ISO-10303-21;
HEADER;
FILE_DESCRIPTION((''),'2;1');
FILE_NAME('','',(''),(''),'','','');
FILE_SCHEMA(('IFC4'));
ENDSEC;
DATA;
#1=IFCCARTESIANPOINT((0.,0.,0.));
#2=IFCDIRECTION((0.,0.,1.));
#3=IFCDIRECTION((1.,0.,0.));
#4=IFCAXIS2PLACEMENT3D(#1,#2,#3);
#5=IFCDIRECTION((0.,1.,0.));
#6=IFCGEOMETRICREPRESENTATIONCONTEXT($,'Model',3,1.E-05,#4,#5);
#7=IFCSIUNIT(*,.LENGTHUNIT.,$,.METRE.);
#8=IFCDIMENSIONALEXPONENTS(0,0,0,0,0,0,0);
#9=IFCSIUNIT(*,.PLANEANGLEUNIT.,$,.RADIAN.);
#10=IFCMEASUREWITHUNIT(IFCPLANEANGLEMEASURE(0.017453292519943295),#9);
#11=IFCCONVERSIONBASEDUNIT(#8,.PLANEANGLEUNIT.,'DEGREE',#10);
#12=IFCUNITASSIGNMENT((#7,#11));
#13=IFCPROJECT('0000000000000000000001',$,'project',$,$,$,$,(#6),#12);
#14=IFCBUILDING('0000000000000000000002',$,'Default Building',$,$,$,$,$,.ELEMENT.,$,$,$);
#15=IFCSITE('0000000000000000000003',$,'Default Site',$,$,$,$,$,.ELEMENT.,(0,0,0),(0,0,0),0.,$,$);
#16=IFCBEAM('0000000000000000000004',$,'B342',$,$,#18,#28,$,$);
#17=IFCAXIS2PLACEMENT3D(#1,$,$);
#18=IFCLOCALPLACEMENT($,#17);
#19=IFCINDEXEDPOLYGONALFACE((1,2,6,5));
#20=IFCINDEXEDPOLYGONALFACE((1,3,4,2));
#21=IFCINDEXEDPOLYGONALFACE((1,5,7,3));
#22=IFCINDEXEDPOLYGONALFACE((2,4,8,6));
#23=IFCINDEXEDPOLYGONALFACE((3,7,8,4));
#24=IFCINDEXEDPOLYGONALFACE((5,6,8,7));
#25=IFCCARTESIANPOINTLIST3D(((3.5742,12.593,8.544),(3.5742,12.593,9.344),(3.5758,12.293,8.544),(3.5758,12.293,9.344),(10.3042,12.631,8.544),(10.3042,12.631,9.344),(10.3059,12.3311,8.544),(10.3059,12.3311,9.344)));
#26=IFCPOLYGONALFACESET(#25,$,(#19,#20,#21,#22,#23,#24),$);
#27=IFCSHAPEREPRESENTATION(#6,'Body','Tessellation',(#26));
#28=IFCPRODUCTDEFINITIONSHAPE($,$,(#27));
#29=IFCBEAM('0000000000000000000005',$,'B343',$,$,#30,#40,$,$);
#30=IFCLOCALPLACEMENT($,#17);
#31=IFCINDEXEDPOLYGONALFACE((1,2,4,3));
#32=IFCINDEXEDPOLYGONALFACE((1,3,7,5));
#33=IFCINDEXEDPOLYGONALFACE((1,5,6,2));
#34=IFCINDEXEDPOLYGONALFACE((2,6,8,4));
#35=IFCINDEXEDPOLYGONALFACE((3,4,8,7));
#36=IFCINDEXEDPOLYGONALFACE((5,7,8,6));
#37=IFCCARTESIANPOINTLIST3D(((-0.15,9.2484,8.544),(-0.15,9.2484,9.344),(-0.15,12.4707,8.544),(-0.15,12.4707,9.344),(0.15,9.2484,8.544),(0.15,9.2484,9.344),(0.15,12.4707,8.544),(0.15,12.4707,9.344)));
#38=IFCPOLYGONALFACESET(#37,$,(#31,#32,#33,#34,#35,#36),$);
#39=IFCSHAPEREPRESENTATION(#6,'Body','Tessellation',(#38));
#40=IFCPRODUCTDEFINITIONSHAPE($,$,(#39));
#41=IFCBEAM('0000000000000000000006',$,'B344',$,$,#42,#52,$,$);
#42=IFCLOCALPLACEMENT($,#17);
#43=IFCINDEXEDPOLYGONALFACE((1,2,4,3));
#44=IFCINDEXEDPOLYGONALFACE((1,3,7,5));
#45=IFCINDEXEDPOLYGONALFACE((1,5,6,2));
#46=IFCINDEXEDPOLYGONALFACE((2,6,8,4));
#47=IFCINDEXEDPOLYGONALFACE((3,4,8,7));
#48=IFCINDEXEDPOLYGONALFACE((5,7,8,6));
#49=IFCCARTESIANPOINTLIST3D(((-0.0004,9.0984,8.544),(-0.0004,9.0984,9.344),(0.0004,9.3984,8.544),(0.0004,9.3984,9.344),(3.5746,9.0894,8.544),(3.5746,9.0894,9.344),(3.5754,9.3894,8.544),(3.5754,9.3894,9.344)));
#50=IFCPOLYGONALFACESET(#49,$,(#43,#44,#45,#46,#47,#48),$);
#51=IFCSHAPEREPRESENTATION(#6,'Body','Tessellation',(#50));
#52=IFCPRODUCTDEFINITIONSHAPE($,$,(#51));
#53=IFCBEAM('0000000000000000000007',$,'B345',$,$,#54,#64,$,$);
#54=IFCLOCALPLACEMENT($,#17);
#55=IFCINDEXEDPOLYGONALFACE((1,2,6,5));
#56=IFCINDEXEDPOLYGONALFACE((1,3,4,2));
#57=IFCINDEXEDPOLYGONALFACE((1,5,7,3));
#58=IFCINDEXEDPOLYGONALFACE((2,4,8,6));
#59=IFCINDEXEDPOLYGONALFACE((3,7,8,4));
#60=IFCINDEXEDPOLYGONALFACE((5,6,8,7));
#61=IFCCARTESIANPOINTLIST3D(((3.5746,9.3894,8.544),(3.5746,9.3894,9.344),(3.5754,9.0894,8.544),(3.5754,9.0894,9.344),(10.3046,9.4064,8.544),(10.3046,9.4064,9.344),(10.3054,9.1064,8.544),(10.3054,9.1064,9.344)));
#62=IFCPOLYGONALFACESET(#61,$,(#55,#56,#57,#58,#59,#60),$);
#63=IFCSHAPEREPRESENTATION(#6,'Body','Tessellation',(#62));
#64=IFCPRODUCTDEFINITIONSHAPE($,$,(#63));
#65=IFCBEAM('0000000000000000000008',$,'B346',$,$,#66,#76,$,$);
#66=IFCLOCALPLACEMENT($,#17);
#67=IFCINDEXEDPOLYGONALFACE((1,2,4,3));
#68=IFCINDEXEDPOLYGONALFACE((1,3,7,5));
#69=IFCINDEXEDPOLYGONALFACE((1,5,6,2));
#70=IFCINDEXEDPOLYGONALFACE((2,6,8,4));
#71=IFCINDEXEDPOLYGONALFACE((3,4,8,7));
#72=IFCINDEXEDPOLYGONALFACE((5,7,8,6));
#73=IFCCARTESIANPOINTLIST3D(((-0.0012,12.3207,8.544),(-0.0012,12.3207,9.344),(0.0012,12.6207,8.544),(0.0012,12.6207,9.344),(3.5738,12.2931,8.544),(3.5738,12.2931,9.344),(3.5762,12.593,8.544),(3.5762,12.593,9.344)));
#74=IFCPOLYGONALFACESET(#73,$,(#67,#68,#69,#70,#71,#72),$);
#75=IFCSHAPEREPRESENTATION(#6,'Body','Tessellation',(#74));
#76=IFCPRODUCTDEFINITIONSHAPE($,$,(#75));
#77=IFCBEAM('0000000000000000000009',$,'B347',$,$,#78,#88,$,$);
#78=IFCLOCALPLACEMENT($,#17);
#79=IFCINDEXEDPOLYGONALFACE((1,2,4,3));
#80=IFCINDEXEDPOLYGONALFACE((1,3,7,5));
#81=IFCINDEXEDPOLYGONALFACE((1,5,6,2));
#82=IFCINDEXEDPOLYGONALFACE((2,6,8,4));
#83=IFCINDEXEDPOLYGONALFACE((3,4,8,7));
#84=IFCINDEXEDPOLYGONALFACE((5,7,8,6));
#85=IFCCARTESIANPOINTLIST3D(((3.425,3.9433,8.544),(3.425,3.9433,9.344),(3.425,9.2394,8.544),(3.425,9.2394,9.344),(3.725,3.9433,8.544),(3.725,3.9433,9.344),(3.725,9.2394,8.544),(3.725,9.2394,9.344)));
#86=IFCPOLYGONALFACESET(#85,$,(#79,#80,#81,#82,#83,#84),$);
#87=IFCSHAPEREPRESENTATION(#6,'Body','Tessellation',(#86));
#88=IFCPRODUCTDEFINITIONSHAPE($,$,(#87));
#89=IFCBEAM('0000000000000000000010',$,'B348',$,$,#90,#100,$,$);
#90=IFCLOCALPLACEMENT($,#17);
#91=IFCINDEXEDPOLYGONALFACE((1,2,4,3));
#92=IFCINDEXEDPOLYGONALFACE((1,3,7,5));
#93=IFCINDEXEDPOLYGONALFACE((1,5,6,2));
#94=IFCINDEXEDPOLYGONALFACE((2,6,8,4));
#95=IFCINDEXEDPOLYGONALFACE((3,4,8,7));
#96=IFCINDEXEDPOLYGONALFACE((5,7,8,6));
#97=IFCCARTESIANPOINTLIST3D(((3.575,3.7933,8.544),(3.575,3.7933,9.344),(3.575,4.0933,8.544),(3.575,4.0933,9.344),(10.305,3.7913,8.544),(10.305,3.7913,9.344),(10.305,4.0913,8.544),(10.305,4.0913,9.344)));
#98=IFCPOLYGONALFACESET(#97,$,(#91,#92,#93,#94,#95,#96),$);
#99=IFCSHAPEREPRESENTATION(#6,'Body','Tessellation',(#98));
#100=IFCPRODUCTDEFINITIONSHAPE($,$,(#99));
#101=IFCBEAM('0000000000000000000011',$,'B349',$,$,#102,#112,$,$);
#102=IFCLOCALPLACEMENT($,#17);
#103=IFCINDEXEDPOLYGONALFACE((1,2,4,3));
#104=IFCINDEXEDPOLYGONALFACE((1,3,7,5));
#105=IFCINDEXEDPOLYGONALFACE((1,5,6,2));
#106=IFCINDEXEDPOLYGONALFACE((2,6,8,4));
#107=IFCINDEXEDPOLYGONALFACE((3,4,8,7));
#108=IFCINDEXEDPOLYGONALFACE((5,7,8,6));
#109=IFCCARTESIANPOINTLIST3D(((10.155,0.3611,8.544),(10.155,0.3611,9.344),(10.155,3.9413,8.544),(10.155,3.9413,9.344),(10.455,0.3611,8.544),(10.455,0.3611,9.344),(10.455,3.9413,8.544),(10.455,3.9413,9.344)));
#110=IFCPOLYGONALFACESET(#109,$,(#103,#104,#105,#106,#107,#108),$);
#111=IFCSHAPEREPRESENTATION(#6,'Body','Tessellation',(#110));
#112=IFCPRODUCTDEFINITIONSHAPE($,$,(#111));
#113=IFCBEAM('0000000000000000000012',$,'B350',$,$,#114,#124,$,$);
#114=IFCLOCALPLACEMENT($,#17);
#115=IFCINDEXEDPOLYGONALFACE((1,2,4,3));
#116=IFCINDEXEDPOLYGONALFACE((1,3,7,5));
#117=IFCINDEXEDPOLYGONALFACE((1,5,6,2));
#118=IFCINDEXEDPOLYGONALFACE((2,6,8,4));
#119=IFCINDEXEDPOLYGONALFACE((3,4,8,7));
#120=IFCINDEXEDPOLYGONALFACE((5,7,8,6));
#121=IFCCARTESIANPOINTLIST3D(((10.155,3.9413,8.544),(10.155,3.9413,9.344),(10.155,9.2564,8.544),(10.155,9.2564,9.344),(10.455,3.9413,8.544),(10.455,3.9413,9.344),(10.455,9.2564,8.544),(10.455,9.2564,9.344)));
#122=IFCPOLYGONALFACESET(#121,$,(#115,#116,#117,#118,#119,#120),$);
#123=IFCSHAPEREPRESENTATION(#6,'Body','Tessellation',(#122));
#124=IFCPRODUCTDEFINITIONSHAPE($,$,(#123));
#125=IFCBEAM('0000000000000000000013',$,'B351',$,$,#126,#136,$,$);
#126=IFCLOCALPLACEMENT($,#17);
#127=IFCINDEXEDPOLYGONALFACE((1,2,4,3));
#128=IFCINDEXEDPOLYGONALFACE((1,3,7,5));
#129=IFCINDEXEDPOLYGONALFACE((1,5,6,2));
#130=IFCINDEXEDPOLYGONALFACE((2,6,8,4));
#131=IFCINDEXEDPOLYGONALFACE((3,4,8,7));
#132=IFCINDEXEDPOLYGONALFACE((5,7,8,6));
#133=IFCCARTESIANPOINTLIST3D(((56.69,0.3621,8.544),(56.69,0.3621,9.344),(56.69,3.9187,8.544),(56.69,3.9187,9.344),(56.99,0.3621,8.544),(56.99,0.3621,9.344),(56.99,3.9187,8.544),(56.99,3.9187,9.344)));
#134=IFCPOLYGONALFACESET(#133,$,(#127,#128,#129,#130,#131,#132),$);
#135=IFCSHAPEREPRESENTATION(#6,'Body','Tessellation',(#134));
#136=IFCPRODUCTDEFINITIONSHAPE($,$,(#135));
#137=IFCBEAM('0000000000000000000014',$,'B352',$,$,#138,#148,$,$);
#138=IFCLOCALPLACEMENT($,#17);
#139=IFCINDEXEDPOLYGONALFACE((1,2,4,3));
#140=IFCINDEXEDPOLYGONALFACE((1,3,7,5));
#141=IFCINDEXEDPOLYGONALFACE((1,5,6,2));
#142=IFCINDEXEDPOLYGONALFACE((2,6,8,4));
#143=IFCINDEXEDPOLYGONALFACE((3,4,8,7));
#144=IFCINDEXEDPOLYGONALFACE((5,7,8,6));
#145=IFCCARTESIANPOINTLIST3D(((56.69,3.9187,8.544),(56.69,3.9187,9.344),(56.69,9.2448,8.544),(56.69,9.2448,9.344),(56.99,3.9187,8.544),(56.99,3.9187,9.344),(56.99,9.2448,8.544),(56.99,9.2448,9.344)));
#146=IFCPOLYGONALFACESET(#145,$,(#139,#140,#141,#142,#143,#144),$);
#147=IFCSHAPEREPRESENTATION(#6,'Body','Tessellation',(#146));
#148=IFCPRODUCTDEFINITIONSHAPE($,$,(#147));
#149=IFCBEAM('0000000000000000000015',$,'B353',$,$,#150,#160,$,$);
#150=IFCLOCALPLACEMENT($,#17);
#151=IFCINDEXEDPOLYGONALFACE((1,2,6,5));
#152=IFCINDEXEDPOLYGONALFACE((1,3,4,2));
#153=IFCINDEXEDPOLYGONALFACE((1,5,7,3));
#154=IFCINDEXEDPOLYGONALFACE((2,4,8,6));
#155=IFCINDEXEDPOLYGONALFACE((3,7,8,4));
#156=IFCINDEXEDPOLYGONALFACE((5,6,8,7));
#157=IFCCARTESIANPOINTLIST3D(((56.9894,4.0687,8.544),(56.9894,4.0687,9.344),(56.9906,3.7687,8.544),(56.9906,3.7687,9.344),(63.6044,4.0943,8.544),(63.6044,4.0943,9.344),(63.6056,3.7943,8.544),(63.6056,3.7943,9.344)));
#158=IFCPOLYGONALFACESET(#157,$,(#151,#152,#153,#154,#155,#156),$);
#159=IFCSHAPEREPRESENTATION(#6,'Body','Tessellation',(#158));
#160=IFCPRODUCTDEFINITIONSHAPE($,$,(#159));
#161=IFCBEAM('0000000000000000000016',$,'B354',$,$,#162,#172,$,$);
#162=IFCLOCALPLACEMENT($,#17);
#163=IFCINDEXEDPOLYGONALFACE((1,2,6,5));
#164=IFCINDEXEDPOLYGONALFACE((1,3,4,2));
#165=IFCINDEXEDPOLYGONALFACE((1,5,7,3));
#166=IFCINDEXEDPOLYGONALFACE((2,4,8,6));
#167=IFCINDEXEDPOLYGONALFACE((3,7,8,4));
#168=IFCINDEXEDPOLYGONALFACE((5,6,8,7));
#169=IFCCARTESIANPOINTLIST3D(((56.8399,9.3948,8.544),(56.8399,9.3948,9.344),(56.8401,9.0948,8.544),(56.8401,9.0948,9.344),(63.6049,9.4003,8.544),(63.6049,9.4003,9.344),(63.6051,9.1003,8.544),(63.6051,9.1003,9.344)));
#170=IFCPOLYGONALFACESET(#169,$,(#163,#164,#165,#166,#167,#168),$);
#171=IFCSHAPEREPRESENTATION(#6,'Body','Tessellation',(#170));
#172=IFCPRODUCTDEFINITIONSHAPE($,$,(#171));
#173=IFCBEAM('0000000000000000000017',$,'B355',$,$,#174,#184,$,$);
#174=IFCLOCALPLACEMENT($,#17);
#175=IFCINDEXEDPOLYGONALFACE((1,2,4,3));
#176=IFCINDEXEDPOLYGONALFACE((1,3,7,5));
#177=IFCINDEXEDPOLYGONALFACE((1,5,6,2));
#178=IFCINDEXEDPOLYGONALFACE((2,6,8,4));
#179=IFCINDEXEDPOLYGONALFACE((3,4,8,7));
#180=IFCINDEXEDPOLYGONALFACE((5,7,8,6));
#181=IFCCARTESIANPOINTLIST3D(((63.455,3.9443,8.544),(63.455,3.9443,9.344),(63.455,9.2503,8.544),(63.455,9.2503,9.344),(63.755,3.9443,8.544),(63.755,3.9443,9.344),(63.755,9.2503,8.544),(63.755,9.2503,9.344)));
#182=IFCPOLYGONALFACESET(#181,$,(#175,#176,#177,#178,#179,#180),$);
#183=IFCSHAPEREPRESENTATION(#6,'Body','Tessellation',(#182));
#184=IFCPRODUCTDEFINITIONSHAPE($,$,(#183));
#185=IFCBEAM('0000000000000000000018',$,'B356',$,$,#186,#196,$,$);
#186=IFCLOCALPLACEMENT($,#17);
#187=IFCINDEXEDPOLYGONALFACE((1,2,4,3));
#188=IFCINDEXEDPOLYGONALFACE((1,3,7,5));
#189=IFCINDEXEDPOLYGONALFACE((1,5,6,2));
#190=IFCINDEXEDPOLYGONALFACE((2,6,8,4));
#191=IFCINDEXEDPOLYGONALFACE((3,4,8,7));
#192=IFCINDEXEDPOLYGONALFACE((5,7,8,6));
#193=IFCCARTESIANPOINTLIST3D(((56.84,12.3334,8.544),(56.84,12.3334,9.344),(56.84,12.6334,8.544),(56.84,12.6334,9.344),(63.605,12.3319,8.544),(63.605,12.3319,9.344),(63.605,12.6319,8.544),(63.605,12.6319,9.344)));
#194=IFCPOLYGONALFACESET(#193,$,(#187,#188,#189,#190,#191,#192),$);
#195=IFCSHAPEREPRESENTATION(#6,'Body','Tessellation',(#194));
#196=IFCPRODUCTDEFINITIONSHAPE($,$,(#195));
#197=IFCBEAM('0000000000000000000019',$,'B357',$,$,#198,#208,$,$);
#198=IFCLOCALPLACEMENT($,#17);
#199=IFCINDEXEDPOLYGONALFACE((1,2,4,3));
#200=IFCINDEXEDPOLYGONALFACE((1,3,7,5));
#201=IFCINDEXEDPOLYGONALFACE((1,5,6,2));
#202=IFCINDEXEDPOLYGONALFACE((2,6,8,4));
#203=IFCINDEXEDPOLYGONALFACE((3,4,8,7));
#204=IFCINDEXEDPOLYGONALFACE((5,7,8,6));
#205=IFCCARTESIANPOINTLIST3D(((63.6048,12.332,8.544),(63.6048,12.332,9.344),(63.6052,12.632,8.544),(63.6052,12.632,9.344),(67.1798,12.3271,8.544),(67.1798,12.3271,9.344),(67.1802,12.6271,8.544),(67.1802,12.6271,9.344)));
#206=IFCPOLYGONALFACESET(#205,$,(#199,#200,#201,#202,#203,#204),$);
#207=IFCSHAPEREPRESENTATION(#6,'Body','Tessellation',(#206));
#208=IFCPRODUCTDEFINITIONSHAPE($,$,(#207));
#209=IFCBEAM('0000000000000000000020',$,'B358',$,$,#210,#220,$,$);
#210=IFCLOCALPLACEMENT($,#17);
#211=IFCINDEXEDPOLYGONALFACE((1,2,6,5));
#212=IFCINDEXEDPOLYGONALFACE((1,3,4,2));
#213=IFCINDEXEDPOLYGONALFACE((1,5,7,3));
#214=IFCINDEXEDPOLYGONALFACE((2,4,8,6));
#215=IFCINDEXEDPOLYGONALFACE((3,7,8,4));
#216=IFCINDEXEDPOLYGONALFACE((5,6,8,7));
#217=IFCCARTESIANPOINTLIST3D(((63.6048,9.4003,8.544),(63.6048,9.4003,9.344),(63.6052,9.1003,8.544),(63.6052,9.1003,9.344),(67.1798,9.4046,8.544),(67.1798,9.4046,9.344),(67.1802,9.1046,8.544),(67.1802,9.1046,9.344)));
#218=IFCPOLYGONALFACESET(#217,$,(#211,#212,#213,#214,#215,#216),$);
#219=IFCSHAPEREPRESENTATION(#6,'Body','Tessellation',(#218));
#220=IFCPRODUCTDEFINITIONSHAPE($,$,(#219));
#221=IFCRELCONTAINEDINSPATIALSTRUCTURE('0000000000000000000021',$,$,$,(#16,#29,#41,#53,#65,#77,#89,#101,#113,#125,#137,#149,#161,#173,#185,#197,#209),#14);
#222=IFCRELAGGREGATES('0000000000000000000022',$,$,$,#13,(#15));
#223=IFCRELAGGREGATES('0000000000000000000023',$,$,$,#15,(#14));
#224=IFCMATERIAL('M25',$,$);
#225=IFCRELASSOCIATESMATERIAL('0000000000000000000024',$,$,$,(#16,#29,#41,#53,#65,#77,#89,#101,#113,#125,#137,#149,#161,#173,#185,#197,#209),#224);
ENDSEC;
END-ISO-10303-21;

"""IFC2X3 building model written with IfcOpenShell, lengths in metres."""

from ifc_helpers import new_model, entity, si_unit, converted_unit, direction, frame, frame_2d, origin_with_axes, place, context, project, spatial, rectangle, extrude, material, element, save


model = new_model("IFC2X3")

# Units and contexts
model_context = context("Model", 3, precision=1e-05, world=origin_with_axes(), true_north=direction((0.0, 1.0, 0.0)))
ifc_project = project(units=[si_unit("LENGTHUNIT", "METRE"), converted_unit("PLANEANGLEUNIT", "DEGREE", entity("IfcPlaneAngleMeasure", 0.017453292519943295), si_unit("PLANEANGLEUNIT", "RADIAN"), dimensions=[0, 0, 0, 0, 0, 0, 0])], contexts=[model_context])

# Site, building
site = spatial("IfcSite", under=ifc_project, Name="Default Site", CompositionType="ELEMENT", RefLatitude=(0, 0, 0), RefLongitude=(0, 0, 0), RefElevation=0.0)
building = spatial("IfcBuilding", under=site, Name="Default Building", CompositionType="ELEMENT")

# Beams
ifc_material = material(Name="M25")
placement = place(None, origin_with_axes())
element("IfcBeam", 1, at=placement, inside=building, material=ifc_material, Name="B342", context=model_context, shape_type="SweptSolid", body=[
    extrude(rectangle(XDim=0.3, YDim=0.8, at=frame_2d((0.0, 0.0), x_axis=(0.0, 1.0, 0.0))), frame((3.575, 12.443, 8.944), z_axis=(0.999984, 0.005654, 0.0), x_axis=(0.0, 0.0, -1.0)), (0.0, 0.0, 1.0), 6.7301),
])
element("IfcBeam", 2, at=placement, inside=building, material=ifc_material, Name="B343", context=model_context, shape_type="SweptSolid", body=[
    extrude(rectangle(XDim=0.3, YDim=0.8, at=frame_2d((0.0, 0.0), x_axis=(0.0, 1.0, 0.0))), frame((0.0, 9.2484, 8.944), z_axis=(0.0, 1.0, 0.0), x_axis=(0.0, 0.0, -1.0)), (0.0, 0.0, 1.0), 3.2223),
])
element("IfcBeam", 3, at=placement, inside=building, material=ifc_material, Name="B344", context=model_context, shape_type="SweptSolid", body=[
    extrude(rectangle(XDim=0.3, YDim=0.8, at=frame_2d((0.0, 0.0), x_axis=(0.0, 1.0, 0.0))), frame((0.0, 9.2484, 8.944), z_axis=(0.999997, -0.002499, 0.0), x_axis=(0.0, 0.0, -1.0)), (0.0, 0.0, 1.0), 3.575),
])
element("IfcBeam", 4, at=placement, inside=building, material=ifc_material, Name="B345", context=model_context, shape_type="SweptSolid", body=[
    extrude(rectangle(XDim=0.3, YDim=0.8, at=frame_2d((0.0, 0.0), x_axis=(0.0, 1.0, 0.0))), frame((3.575, 9.2394, 8.944), z_axis=(0.999997, 0.002522, 0.0), x_axis=(0.0, 0.0, -1.0)), (0.0, 0.0, 1.0), 6.73),
])
element("IfcBeam", 5, at=placement, inside=building, material=ifc_material, Name="B346", context=model_context, shape_type="SweptSolid", body=[
    extrude(rectangle(XDim=0.3, YDim=0.8, at=frame_2d((0.0, 0.0), x_axis=(0.0, 1.0, 0.0))), frame((0.0, 12.4707, 8.944), z_axis=(0.99997, -0.007734, 0.0), x_axis=(0.0, 0.0, -1.0)), (0.0, 0.0, 1.0), 3.5751),
])
element("IfcBeam", 6, at=placement, inside=building, material=ifc_material, Name="B347", context=model_context, shape_type="SweptSolid", body=[
    extrude(rectangle(XDim=0.3, YDim=0.8, at=frame_2d((0.0, 0.0), x_axis=(0.0, 1.0, 0.0))), frame((3.575, 3.9433, 8.944), z_axis=(0.0, 1.0, 0.0), x_axis=(0.0, 0.0, -1.0)), (0.0, 0.0, 1.0), 5.2961),
])
element("IfcBeam", 7, at=placement, inside=building, material=ifc_material, Name="B348", context=model_context, shape_type="SweptSolid", body=[
    extrude(rectangle(XDim=0.3, YDim=0.8, at=frame_2d((0.0, 0.0), x_axis=(0.0, 1.0, 0.0))), frame((3.575, 3.9433, 8.944), z_axis=(1.0, -0.000302, 0.0), x_axis=(0.0, 0.0, -1.0)), (0.0, 0.0, 1.0), 6.73),
])
element("IfcBeam", 8, at=placement, inside=building, material=ifc_material, Name="B349", context=model_context, shape_type="SweptSolid", body=[
    extrude(rectangle(XDim=0.3, YDim=0.8, at=frame_2d((0.0, 0.0), x_axis=(0.0, 1.0, 0.0))), frame((10.305, 3.9413, 8.944), z_axis=(0.0, -1.0, 0.0), x_axis=(0.0, 0.0, -1.0)), (0.0, 0.0, 1.0), 3.5802),
])
element("IfcBeam", 9, at=placement, inside=building, material=ifc_material, Name="B350", context=model_context, shape_type="SweptSolid", body=[
    extrude(rectangle(XDim=0.3, YDim=0.8, at=frame_2d((0.0, 0.0), x_axis=(0.0, 1.0, 0.0))), frame((10.305, 3.9413, 8.944), z_axis=(0.0, 1.0, 0.0), x_axis=(0.0, 0.0, -1.0)), (0.0, 0.0, 1.0), 5.3151),
])
element("IfcBeam", 10, at=placement, inside=building, material=ifc_material, Name="B351", context=model_context, shape_type="SweptSolid", body=[
    extrude(rectangle(XDim=0.3, YDim=0.8, at=frame_2d((0.0, 0.0), x_axis=(0.0, 1.0, 0.0))), frame((56.84, 0.3621, 8.944), z_axis=(0.0, 1.0, 0.0), x_axis=(0.0, 0.0, -1.0)), (0.0, 0.0, 1.0), 3.5566),
])
element("IfcBeam", 11, at=placement, inside=building, material=ifc_material, Name="B352", context=model_context, shape_type="SweptSolid", body=[
    extrude(rectangle(XDim=0.3, YDim=0.8, at=frame_2d((0.0, 0.0), x_axis=(0.0, 1.0, 0.0))), frame((56.84, 3.9187, 8.944), z_axis=(0.0, 1.0, 0.0), x_axis=(0.0, 0.0, -1.0)), (0.0, 0.0, 1.0), 5.3261),
])
element("IfcBeam", 12, at=placement, inside=building, material=ifc_material, Name="B353", context=model_context, shape_type="SweptSolid", body=[
    extrude(rectangle(XDim=0.3, YDim=0.8, at=frame_2d((0.0, 0.0), x_axis=(0.0, 1.0, 0.0))), frame((56.99, 3.9187, 8.944), z_axis=(0.999993, 0.003873, 0.0), x_axis=(0.0, 0.0, -1.0)), (0.0, 0.0, 1.0), 6.6151),
])
element("IfcBeam", 13, at=placement, inside=building, material=ifc_material, Name="B354", context=model_context, shape_type="SweptSolid", body=[
    extrude(rectangle(XDim=0.3, YDim=0.8, at=frame_2d((0.0, 0.0), x_axis=(0.0, 1.0, 0.0))), frame((56.84, 9.2448, 8.944), z_axis=(1.0, 0.000816, 0.0), x_axis=(0.0, 0.0, -1.0)), (0.0, 0.0, 1.0), 6.765),
])
element("IfcBeam", 14, at=placement, inside=building, material=ifc_material, Name="B355", context=model_context, shape_type="SweptSolid", body=[
    extrude(rectangle(XDim=0.3, YDim=0.8, at=frame_2d((0.0, 0.0), x_axis=(0.0, 1.0, 0.0))), frame((63.605, 3.9443, 8.944), z_axis=(0.0, 1.0, 0.0), x_axis=(0.0, 0.0, -1.0)), (0.0, 0.0, 1.0), 5.306),
])
element("IfcBeam", 15, at=placement, inside=building, material=ifc_material, Name="B356", context=model_context, shape_type="SweptSolid", body=[
    extrude(rectangle(XDim=0.3, YDim=0.8, at=frame_2d((0.0, 0.0), x_axis=(0.0, 1.0, 0.0))), frame((56.84, 12.4834, 8.944), z_axis=(1.0, -0.000216, 0.0), x_axis=(0.0, 0.0, -1.0)), (0.0, 0.0, 1.0), 6.765),
])
element("IfcBeam", 16, at=placement, inside=building, material=ifc_material, Name="B357", context=model_context, shape_type="SweptSolid", body=[
    extrude(rectangle(XDim=0.3, YDim=0.8, at=frame_2d((0.0, 0.0), x_axis=(0.0, 1.0, 0.0))), frame((63.605, 12.482, 8.944), z_axis=(0.999999, -0.001379, 0.0), x_axis=(0.0, 0.0, -1.0)), (0.0, 0.0, 1.0), 3.575),
])
element("IfcBeam", 17, at=placement, inside=building, material=ifc_material, Name="B358", context=model_context, shape_type="SweptSolid", body=[
    extrude(rectangle(XDim=0.3, YDim=0.8, at=frame_2d((0.0, 0.0), x_axis=(0.0, 1.0, 0.0))), frame((63.605, 9.2503, 8.944), z_axis=(0.999999, 0.001188, 0.0), x_axis=(0.0, 0.0, -1.0)), (0.0, 0.0, 1.0), 3.575),
])

save(model, "model.ifc")
